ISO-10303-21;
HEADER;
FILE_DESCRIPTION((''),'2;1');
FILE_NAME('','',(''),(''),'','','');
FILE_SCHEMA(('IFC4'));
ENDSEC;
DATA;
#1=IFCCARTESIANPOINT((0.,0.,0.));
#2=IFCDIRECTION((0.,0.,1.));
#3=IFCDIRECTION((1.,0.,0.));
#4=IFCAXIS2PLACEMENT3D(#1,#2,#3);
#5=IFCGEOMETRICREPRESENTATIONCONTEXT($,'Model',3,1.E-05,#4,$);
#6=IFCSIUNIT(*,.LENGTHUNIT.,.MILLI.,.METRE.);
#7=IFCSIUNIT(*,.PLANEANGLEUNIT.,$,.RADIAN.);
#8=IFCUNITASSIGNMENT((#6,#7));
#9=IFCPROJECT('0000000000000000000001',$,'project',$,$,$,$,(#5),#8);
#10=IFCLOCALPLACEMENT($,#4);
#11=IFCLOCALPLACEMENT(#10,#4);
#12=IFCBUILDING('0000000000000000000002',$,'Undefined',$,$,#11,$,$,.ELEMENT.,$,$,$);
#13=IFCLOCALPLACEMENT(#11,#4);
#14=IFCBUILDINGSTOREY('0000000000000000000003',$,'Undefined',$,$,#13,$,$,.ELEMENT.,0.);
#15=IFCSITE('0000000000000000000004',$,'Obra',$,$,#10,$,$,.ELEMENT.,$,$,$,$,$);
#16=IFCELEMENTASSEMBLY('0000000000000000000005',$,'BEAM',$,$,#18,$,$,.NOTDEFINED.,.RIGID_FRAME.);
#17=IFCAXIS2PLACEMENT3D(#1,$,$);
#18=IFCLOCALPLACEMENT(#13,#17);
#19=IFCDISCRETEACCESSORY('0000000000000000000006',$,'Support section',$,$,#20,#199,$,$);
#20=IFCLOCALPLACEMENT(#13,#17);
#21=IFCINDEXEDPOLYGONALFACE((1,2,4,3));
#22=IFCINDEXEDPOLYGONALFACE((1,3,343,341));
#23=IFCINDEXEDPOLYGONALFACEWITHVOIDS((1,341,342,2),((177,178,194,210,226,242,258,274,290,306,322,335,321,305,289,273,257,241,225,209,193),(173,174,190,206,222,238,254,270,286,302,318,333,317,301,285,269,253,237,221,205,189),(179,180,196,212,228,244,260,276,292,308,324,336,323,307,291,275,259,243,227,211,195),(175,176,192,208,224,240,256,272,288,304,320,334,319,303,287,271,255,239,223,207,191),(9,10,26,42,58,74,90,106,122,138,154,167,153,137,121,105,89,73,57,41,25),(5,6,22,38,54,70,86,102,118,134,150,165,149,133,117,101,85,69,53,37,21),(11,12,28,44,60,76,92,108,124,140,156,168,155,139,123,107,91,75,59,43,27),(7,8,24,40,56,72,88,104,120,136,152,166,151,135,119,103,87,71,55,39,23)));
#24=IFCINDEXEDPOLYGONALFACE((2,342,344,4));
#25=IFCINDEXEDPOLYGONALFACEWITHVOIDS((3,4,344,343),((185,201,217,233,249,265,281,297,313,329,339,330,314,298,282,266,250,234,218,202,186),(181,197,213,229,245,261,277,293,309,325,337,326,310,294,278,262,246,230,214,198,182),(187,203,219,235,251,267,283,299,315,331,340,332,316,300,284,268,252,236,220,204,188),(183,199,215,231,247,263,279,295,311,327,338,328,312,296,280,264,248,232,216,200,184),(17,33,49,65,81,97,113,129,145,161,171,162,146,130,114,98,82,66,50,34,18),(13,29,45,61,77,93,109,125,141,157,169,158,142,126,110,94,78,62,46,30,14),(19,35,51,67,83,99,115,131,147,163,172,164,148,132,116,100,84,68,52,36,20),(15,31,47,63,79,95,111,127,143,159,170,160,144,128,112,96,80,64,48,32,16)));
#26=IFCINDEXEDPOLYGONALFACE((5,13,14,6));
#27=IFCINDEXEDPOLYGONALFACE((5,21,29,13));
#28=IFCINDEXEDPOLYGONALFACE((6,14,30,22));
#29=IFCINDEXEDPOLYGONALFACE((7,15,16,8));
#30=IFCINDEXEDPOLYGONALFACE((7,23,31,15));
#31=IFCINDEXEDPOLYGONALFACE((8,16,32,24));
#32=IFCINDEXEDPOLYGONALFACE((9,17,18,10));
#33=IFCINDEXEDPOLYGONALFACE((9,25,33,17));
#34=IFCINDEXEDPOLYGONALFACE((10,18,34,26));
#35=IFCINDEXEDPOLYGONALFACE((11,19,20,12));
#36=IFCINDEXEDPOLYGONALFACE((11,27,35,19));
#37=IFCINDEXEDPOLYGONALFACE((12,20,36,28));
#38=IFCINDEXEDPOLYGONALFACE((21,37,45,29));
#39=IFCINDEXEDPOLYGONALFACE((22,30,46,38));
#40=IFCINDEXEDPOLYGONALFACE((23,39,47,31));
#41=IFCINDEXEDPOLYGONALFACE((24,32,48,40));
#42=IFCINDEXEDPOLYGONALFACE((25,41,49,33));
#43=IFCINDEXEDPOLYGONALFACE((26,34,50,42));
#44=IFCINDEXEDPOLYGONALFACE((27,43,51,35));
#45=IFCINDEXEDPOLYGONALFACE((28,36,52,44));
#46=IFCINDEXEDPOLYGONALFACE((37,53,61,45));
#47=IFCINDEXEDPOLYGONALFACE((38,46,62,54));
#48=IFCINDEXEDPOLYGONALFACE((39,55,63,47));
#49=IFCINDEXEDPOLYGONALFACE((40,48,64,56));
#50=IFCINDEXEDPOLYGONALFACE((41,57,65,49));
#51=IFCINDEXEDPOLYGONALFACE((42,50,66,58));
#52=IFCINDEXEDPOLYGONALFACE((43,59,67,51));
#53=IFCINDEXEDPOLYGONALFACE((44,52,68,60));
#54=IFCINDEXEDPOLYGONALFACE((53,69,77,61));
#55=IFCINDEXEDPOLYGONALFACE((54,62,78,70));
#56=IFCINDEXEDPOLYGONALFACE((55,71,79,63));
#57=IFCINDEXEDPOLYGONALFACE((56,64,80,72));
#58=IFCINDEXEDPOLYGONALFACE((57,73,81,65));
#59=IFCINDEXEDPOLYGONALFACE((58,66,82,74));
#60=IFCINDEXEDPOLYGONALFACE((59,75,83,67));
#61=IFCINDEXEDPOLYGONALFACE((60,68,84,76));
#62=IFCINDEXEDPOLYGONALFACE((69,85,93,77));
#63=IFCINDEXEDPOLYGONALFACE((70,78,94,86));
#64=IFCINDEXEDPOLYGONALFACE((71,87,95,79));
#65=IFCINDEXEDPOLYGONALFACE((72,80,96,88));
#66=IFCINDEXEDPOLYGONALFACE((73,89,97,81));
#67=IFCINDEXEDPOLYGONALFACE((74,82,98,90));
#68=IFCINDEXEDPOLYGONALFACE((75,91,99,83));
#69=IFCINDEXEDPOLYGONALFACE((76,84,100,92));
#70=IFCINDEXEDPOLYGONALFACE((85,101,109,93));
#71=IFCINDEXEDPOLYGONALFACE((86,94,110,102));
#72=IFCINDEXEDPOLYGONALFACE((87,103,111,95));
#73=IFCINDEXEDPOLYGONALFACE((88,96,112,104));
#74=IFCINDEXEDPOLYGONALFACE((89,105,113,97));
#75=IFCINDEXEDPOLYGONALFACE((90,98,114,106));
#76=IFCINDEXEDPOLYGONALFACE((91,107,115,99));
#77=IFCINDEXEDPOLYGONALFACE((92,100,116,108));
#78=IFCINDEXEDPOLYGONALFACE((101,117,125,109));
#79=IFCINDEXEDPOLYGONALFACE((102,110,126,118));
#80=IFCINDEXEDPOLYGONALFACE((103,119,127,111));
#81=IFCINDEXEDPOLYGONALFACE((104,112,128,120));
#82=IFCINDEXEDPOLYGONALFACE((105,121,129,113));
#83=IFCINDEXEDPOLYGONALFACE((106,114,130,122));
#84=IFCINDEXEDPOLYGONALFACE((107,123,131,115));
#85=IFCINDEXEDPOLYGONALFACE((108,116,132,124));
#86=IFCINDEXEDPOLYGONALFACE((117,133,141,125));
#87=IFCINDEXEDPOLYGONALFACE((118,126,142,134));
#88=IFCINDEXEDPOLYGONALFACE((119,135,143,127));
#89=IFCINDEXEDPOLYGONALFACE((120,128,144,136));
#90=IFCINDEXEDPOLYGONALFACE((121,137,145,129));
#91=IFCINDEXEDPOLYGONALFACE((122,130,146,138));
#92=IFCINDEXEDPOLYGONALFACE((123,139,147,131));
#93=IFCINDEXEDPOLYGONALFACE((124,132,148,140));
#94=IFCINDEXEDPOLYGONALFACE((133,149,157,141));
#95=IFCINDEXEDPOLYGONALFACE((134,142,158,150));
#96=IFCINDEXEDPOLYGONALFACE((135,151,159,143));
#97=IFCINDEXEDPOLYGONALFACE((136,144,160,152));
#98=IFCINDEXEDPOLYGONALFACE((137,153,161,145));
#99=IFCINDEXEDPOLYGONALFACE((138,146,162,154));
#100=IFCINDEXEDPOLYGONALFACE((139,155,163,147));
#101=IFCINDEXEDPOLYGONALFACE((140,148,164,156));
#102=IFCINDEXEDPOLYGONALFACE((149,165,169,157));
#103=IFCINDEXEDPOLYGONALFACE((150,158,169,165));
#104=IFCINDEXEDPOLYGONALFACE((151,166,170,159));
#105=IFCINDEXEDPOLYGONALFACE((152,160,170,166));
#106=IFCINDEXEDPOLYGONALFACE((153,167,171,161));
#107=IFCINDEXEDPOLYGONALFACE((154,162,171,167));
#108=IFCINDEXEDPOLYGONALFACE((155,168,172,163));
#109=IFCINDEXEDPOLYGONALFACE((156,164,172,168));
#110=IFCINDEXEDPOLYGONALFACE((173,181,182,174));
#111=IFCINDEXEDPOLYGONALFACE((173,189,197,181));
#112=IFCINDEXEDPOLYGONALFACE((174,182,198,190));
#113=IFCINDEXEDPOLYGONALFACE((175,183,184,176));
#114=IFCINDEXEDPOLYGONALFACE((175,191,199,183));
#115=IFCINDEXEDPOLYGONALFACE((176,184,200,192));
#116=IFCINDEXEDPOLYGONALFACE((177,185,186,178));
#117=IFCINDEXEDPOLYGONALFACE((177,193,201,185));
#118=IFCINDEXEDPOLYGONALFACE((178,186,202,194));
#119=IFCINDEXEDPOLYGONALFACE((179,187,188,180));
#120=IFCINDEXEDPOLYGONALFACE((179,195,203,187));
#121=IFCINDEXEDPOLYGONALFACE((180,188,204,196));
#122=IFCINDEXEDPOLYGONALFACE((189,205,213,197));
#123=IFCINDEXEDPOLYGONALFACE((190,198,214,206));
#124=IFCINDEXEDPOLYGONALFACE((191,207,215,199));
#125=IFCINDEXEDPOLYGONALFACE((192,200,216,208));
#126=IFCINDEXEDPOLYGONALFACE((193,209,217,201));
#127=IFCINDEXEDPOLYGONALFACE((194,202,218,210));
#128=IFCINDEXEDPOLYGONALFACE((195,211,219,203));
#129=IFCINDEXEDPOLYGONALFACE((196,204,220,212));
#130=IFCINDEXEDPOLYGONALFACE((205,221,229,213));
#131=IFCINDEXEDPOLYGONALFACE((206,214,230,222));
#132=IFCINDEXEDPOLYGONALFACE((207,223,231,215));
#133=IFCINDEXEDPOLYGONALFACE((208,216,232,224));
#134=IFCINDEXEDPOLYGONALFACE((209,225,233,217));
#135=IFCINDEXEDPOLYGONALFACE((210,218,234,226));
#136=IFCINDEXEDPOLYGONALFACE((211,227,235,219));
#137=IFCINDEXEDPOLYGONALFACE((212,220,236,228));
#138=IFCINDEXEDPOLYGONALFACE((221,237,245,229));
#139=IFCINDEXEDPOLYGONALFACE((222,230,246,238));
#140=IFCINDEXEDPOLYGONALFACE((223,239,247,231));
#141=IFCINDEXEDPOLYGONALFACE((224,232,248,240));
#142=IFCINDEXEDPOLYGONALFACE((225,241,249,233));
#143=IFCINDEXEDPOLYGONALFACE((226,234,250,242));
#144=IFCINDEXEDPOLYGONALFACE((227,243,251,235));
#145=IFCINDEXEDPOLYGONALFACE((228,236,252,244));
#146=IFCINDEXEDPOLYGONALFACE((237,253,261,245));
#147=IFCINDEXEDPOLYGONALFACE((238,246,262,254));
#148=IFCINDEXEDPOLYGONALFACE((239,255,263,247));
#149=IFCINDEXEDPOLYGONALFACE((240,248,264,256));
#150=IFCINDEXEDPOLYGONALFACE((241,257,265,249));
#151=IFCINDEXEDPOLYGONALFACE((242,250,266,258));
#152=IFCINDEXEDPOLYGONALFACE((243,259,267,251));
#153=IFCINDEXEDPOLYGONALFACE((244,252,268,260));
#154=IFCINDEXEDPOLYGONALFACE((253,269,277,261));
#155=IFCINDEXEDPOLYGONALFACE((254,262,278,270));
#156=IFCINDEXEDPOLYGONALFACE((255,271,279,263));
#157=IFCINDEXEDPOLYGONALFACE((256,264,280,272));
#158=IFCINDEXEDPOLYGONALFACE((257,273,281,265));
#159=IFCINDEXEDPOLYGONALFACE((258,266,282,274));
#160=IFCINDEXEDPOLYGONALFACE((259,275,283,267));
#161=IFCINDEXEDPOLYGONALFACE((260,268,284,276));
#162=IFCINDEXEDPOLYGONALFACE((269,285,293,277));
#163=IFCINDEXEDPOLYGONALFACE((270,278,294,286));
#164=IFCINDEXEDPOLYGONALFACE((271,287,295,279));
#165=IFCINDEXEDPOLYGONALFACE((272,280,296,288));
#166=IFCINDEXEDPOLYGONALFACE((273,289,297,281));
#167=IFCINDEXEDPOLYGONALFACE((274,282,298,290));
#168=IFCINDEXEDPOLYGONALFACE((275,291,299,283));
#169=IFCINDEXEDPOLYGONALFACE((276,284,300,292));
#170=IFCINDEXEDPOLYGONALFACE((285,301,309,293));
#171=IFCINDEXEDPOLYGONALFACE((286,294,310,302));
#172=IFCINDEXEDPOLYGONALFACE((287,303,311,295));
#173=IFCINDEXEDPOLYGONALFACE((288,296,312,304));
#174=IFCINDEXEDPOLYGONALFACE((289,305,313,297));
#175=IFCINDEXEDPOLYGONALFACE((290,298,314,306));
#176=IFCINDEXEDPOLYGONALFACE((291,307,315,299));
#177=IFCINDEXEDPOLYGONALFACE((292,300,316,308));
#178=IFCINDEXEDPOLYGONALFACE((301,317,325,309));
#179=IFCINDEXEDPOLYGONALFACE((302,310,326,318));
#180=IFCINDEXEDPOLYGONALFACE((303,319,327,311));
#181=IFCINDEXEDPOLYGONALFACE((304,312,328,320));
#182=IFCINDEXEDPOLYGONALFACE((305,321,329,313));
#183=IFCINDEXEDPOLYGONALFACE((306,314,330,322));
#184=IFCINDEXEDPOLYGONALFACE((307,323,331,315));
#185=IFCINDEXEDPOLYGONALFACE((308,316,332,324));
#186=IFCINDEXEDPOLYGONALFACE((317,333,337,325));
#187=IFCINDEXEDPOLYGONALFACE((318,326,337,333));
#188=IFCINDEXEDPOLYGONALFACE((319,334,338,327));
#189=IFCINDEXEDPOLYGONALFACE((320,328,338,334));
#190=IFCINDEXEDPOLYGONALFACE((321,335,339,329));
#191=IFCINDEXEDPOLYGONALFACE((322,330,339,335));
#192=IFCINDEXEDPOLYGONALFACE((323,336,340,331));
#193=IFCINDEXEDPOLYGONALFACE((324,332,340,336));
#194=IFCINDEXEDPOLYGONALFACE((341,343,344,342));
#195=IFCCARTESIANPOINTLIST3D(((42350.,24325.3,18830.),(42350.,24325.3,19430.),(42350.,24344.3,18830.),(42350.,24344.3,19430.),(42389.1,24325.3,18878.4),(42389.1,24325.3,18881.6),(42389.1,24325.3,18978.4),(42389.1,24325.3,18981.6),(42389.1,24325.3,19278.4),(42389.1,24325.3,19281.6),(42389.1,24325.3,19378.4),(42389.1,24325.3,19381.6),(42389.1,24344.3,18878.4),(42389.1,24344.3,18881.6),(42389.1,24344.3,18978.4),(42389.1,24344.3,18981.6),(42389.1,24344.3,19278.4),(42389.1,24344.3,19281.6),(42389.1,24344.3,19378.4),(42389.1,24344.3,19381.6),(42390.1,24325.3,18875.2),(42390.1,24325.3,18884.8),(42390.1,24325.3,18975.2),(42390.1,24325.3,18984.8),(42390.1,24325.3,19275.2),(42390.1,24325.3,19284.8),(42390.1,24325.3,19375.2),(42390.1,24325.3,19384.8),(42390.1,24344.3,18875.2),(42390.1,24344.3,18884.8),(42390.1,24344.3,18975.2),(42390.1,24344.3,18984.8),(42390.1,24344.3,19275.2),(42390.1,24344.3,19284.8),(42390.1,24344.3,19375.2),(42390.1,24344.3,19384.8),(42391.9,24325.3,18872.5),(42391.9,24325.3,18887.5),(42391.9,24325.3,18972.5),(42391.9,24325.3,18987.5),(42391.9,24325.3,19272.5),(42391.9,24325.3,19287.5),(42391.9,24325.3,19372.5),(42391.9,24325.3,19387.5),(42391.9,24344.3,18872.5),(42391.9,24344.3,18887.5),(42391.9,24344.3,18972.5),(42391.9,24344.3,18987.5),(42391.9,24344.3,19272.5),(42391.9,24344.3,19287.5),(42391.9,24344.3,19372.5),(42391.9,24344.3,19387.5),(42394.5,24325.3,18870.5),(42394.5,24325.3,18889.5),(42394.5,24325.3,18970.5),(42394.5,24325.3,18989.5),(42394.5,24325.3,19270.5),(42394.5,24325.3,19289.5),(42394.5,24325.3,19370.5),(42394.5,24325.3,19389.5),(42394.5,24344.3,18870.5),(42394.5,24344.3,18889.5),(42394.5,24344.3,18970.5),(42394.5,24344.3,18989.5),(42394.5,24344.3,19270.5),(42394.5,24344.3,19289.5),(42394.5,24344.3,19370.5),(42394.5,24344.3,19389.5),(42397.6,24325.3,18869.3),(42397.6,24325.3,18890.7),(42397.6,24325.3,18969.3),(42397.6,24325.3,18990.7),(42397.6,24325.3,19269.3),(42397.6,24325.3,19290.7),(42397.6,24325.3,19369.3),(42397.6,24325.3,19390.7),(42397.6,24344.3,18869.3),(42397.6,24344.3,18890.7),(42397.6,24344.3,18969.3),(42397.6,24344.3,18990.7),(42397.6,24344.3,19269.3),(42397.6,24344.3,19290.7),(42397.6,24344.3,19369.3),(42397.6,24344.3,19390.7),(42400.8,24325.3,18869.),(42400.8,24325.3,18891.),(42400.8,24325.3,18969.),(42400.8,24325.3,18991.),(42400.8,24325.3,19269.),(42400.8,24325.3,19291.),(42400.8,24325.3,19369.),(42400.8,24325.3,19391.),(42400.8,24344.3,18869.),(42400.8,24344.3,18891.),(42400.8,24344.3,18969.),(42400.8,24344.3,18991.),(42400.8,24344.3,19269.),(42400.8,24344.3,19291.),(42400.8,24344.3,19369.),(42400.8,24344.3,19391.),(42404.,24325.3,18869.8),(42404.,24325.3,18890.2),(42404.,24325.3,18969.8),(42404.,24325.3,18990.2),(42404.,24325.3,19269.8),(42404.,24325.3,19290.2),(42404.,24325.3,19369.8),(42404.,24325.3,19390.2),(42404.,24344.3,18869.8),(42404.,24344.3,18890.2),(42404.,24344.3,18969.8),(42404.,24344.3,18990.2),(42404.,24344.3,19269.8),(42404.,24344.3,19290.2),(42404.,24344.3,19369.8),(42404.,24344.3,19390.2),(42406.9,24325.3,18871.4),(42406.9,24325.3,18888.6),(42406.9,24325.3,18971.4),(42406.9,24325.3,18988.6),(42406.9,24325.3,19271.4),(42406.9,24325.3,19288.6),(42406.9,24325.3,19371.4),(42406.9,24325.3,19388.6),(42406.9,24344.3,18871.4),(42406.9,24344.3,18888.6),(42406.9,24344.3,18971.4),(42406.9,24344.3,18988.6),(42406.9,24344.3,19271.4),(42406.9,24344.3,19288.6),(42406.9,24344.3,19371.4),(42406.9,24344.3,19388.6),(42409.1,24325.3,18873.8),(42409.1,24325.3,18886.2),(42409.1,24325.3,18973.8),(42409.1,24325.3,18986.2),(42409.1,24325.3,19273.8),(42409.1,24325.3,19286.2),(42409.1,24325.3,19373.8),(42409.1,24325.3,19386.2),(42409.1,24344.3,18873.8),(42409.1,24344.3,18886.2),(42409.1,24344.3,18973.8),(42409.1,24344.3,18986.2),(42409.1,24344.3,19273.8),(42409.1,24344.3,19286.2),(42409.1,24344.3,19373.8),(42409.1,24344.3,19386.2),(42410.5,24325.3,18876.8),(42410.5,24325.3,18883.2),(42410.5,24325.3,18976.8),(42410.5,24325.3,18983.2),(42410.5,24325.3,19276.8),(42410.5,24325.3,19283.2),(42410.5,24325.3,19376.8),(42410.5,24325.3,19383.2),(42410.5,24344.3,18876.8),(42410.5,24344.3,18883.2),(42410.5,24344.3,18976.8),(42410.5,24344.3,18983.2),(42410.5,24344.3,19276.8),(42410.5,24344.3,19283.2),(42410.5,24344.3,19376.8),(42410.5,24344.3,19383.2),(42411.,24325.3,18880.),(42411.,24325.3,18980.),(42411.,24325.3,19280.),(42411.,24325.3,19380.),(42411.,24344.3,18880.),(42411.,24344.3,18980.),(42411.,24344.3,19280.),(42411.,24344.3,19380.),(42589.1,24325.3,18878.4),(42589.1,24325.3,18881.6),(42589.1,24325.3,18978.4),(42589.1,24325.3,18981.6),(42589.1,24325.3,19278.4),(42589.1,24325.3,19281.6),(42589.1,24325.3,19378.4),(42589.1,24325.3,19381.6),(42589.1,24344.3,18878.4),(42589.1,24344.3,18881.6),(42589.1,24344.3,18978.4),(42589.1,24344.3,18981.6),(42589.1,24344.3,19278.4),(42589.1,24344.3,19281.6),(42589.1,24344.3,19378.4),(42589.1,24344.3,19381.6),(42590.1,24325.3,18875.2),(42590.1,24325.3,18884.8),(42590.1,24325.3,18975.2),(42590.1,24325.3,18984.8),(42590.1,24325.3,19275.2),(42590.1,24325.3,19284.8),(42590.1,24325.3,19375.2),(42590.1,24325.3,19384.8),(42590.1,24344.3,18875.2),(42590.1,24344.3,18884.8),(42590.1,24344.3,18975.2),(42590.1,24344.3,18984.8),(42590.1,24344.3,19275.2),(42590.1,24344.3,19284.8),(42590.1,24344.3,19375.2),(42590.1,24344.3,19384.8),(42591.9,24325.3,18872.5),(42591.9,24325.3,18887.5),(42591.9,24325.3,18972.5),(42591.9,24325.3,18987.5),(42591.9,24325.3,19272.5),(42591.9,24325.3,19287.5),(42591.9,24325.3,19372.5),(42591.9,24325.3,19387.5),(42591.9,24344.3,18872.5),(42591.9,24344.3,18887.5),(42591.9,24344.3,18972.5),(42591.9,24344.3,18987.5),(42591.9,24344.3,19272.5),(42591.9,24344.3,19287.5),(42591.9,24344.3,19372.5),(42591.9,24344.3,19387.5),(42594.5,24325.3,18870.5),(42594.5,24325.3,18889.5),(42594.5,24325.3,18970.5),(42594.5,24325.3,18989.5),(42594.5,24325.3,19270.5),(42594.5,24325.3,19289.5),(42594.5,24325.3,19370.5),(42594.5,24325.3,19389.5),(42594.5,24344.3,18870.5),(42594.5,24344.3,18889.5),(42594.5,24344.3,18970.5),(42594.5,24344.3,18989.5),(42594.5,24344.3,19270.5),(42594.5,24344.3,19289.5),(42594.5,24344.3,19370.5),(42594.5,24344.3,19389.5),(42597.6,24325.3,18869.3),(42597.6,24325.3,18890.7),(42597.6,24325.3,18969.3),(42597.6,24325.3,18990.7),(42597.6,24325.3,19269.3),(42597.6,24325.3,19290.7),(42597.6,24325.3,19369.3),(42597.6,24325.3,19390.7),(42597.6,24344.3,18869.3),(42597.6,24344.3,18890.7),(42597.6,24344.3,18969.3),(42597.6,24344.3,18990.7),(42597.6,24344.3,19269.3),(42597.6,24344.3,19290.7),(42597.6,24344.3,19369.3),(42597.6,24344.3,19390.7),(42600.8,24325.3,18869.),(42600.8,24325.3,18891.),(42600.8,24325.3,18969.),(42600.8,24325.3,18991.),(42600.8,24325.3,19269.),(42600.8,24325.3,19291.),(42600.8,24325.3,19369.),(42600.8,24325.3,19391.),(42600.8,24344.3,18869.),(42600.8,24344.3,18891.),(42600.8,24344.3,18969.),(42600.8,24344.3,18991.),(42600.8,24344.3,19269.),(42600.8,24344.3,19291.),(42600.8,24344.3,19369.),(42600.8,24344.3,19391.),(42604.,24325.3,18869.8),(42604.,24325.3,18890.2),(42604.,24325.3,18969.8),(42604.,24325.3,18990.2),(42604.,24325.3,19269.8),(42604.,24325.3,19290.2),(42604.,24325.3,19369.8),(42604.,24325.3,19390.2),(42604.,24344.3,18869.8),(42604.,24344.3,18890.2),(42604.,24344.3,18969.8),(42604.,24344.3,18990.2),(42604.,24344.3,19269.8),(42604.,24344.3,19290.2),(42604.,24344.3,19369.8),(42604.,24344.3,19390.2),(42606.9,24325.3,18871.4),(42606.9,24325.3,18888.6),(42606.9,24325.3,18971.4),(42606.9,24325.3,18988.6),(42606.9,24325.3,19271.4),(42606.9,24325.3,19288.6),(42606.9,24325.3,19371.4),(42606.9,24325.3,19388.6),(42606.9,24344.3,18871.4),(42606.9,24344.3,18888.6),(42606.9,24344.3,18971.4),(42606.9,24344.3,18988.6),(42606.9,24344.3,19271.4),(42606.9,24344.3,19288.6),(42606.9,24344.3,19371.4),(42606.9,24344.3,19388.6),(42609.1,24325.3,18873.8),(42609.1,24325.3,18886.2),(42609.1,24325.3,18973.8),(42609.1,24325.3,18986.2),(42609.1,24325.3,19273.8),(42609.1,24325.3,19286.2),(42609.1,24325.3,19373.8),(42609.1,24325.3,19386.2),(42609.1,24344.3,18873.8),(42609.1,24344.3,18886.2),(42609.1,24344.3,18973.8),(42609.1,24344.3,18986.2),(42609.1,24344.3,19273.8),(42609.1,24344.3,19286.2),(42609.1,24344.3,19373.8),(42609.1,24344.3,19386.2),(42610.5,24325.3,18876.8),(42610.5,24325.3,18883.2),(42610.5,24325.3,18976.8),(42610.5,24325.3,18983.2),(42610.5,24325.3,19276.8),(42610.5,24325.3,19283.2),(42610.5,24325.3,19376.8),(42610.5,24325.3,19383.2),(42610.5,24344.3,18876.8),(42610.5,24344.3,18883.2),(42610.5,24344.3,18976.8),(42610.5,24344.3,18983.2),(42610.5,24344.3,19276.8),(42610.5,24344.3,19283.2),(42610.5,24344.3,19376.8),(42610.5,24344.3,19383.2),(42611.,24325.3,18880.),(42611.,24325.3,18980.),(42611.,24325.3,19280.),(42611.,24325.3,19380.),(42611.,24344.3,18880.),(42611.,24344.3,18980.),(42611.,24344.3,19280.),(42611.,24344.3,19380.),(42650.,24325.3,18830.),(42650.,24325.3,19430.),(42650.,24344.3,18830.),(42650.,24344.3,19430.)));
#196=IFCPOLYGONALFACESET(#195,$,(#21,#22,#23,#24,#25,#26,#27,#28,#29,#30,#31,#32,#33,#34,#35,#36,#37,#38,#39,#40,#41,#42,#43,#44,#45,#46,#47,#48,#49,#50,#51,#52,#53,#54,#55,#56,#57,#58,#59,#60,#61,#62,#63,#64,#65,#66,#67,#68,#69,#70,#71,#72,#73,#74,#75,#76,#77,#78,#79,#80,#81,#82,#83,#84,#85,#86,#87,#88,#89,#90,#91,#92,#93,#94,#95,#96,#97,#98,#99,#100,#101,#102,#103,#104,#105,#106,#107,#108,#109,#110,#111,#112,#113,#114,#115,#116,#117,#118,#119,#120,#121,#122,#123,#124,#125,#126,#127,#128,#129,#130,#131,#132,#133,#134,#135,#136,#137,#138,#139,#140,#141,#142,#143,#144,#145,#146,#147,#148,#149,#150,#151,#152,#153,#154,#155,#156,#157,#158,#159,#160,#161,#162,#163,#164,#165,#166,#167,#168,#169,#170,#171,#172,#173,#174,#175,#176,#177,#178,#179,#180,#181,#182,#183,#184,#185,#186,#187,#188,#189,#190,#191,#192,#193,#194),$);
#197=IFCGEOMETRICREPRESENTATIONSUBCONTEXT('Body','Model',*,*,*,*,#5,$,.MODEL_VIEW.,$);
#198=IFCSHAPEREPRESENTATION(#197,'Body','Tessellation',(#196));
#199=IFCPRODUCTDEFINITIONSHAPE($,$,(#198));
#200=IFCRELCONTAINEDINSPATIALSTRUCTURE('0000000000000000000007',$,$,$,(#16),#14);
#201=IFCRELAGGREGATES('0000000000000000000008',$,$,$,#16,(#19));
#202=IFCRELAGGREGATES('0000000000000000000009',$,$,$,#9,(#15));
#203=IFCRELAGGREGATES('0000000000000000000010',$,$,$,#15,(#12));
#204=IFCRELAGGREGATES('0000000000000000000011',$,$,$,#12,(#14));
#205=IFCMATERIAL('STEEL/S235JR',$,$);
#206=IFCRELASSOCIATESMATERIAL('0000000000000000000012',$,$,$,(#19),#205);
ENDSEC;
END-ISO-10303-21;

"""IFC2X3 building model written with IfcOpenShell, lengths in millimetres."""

from ifc_helpers import new_model, si_unit, frame, origin_with_axes, origin_2d_with_axis, place, context, subcontext, project, spatial, rectangle, circle, extrude, source, transform, mapped, material, element, aggregate, save


model = new_model("IFC2X3")

# Units and contexts
model_context = context("Model", 3, precision=1e-05, world=origin_with_axes())
body_context = subcontext(model_context, "Body", "Model", "MODEL_VIEW")
ifc_project = project(units=[si_unit("LENGTHUNIT", "METRE", prefix="MILLI"), si_unit("PLANEANGLEUNIT", "RADIAN")], contexts=[model_context])

# Site, building, storey
site_placement = place(None, origin_with_axes())
site = spatial("IfcSite", under=ifc_project, at=site_placement, Name="Obra", CompositionType="ELEMENT")
building_placement = place(site_placement, origin_with_axes())
building = spatial("IfcBuilding", under=site, at=building_placement, Name="Undefined", CompositionType="ELEMENT")
storey_placement = place(building_placement, origin_with_axes())
storey = spatial("IfcBuildingStorey", under=building, at=storey_placement, Name="Undefined", CompositionType="ELEMENT", Elevation=0.0)

# Shared definitions
ifc_material_1 = material(Name="STEEL/S235JR")

# Element assembly
assembly_1_placement = place(storey_placement, origin_with_axes())
assembly_1 = element("IfcElementAssembly", 1, at=assembly_1_placement, inside=storey, Name="BEAM", AssemblyPlace="NOTDEFINED", PredefinedType="RIGID_FRAME")

# Discrete accessory, opening
discrete_accessory_1_placement = place(assembly_1_placement, frame((42650.0, 24334.8, 19130.0), z_axis=(0.0, 0.0, -1.0), x_axis=(-1.0, 0.0, 0.0)))
discrete_accessory_1 = element("IfcDiscreteAccessory", 2, at=discrete_accessory_1_placement, material=ifc_material_1, Name="Support section", context=body_context, shape_type="SweptSolid", body=[
    extrude(rectangle(XDim=19.0, YDim=600.0, at=origin_2d_with_axis()), frame((300.0, 0.0, 0.0), z_axis=(-1.0, 0.0, 0.0), x_axis=(0.0, -1.0, 0.0)), (0.0, 0.0, 1.0), 300.0),
])
shared_shape_1 = source(origin_with_axes(), body_context, "Body", "SweptSolid", [
    extrude(circle(Radius=11.0, at=origin_2d_with_axis()), frame((0.0, -0.1, 0.0), z_axis=(0.0, 1.0, 0.0), x_axis=(1.0, 0.0, 0.0)), (0.0, 0.0, 1.0), 19.2),
])
opening_1_placement = place(assembly_1_placement, frame((42350.0, 24344.3, 19130.0), z_axis=(0.0, 0.0, -1.0), x_axis=(1.0, 0.0, 0.0)))
element("IfcOpeningElement", 3, at=opening_1_placement, cuts=discrete_accessory_1, ObjectType="Opening", context=body_context, shape_type="MappedRepresentation", body=[
    mapped(shared_shape_1, transform((50.0, 0.0, -250.0))),
    mapped(shared_shape_1, transform((50.0, 0.0, -150.0))),
    mapped(shared_shape_1, transform((50.0, 0.0, 150.0))),
    mapped(shared_shape_1, transform((50.0, 0.0, 250.0))),
    mapped(shared_shape_1, transform((250.0, 0.0, -250.0))),
    mapped(shared_shape_1, transform((250.0, 0.0, -150.0))),
    mapped(shared_shape_1, transform((250.0, 0.0, 150.0))),
    mapped(shared_shape_1, transform((250.0, 0.0, 250.0))),
])
aggregate(assembly_1, [discrete_accessory_1])

save(model, "model.ifc")
